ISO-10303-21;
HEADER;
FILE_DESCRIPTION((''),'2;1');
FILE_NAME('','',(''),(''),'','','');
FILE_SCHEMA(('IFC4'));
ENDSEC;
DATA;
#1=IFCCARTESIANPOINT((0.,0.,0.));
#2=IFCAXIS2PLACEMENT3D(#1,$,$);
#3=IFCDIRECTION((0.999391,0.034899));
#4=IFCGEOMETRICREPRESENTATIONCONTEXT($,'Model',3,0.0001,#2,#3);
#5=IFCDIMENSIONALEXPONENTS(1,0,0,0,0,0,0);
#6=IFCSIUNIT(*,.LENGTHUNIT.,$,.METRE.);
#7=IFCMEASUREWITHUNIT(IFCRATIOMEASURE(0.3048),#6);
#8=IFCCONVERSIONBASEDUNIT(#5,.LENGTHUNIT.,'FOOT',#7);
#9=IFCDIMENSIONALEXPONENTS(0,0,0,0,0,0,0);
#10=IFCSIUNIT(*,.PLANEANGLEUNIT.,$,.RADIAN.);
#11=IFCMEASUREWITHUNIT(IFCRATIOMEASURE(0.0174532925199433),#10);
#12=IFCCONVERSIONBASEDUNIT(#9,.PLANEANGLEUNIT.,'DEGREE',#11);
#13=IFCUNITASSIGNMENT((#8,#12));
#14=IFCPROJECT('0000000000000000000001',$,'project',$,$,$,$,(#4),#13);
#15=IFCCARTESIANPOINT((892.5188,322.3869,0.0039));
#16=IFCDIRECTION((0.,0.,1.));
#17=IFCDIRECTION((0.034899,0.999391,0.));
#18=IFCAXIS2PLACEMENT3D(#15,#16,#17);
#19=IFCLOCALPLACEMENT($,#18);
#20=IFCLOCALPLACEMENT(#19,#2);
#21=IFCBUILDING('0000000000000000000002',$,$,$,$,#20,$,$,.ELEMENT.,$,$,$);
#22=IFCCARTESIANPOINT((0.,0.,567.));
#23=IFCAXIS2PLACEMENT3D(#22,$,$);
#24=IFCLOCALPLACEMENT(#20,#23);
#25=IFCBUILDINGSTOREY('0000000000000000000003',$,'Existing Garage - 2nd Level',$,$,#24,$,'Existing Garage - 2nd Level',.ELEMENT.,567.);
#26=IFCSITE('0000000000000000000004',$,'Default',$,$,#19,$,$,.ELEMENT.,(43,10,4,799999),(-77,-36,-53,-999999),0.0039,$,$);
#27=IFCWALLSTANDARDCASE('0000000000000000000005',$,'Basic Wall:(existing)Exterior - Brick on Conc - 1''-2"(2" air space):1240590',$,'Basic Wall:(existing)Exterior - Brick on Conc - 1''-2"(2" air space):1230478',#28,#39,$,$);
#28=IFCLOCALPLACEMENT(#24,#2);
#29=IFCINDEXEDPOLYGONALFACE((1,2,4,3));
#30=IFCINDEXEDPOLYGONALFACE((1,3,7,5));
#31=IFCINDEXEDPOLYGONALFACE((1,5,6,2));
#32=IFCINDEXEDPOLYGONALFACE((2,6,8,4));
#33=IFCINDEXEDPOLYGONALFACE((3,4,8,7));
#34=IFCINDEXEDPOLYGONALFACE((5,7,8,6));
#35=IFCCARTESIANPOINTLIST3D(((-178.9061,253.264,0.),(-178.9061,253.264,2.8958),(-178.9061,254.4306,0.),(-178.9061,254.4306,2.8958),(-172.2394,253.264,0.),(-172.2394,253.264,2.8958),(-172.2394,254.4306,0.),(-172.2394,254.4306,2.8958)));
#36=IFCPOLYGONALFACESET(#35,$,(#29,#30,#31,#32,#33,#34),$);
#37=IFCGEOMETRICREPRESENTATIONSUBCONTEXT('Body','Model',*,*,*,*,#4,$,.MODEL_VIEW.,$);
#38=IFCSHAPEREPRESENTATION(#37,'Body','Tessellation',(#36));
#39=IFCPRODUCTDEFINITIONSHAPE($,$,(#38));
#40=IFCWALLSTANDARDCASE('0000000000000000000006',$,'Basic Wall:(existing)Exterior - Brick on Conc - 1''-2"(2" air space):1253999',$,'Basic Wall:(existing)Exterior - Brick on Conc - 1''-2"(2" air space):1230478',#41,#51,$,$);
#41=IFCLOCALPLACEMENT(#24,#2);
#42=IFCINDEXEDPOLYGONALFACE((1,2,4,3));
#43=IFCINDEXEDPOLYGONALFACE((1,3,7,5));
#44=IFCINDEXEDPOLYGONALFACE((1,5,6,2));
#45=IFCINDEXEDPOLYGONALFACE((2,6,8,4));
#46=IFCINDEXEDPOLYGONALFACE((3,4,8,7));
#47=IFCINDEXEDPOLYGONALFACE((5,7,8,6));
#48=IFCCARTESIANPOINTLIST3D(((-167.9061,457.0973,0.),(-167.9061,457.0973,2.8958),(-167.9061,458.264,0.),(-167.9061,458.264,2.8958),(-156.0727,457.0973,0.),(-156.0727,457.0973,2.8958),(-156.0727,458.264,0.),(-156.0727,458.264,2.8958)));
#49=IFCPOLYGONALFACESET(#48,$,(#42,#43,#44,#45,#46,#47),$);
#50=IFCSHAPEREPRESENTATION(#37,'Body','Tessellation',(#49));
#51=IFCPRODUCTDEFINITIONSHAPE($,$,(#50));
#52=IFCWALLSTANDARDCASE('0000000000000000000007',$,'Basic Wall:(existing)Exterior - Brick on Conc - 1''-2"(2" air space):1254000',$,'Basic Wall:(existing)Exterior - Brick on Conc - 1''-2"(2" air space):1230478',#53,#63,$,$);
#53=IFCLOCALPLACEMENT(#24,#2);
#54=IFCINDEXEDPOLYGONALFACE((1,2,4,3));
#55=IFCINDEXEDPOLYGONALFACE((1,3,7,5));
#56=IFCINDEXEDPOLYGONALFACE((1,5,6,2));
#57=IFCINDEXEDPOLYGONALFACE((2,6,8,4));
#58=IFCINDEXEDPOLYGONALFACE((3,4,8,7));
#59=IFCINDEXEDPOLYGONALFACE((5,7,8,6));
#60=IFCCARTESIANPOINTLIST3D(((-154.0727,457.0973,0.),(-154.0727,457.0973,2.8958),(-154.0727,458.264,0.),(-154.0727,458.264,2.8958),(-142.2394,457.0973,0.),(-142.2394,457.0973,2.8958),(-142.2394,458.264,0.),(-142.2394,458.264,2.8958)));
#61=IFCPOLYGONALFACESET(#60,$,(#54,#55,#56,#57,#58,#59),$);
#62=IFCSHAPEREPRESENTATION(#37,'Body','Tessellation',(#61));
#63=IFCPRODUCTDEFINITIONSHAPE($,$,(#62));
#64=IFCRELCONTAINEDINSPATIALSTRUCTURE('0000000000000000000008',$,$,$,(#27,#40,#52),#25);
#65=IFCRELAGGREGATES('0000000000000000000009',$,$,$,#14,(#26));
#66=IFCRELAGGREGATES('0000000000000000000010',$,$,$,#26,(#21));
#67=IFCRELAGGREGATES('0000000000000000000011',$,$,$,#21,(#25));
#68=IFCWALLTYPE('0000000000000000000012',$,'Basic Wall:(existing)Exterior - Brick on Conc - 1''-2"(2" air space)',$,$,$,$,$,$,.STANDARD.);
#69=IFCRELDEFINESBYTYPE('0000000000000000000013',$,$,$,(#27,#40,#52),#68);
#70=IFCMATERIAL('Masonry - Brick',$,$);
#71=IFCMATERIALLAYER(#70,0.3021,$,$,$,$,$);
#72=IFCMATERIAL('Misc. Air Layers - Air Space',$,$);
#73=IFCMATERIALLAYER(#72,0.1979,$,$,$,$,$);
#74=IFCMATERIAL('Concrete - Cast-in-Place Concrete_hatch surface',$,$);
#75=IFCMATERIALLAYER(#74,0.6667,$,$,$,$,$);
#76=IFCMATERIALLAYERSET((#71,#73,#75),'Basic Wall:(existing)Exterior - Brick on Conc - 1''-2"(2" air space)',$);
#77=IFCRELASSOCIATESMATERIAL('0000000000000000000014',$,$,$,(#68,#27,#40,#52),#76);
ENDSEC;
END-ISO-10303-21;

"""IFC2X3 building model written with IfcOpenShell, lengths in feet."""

from ifc_helpers import new_model, entity, si_unit, converted_unit, direction, frame, frame_2d, origin, place, context, subcontext, project, spatial, rectangle, extrude, material, layer, layer_set, layer_usage, type_object, element, save


model = new_model("IFC2X3")

# Units and contexts
model_context = context("Model", 3, precision=0.0001, world=origin(), true_north=direction((0.999391, 0.034899)))
body_context = subcontext(model_context, "Body", "Model", "MODEL_VIEW")
ifc_project = project(units=[converted_unit("LENGTHUNIT", "FOOT", entity("IfcRatioMeasure", 0.3048), si_unit("LENGTHUNIT", "METRE"), dimensions=[1, 0, 0, 0, 0, 0, 0]), converted_unit("PLANEANGLEUNIT", "DEGREE", entity("IfcRatioMeasure", 0.0174532925199433), si_unit("PLANEANGLEUNIT", "RADIAN"), dimensions=[0, 0, 0, 0, 0, 0, 0])], contexts=[model_context])

# Site, building, storey
site_placement = place(None, frame((892.5188, 322.3869, 0.0039), z_axis=(0.0, 0.0, 1.0), x_axis=(0.034899, 0.999391, 0.0)))
site = spatial("IfcSite", under=ifc_project, at=site_placement, Name="Default", CompositionType="ELEMENT", RefLatitude=(43, 10, 4, 799999), RefLongitude=(-77, -36, -53, -999999), RefElevation=0.0039)
building_placement = place(site_placement, origin())
building = spatial("IfcBuilding", under=site, at=building_placement, CompositionType="ELEMENT")
storey_placement = place(building_placement, frame((0.0, 0.0, 567.0)))
storey = spatial("IfcBuildingStorey", under=building, at=storey_placement, Name="Existing Garage - 2nd Level", LongName="Existing Garage - 2nd Level", CompositionType="ELEMENT", Elevation=567.0)

# Walls
ifc_material_1 = material(Name="Masonry - Brick")
ifc_layer_1 = layer(ifc_material_1, 0.3021)
ifc_material_2 = material(Name="Misc. Air Layers - Air Space")
ifc_layer_2 = layer(ifc_material_2, 0.1979)
ifc_material_3 = material(Name="Concrete - Cast-in-Place Concrete_hatch surface")
ifc_layer_3 = layer(ifc_material_3, 0.6667)
ifc_layer_set = layer_set([ifc_layer_1, ifc_layer_2, ifc_layer_3], Name="Basic Wall:(existing)Exterior - Brick on Conc - 1'-2\"(2\" air space)")
ifc_layer_usage_1 = layer_usage(ifc_layer_set, "AXIS2", "POSITIVE", -0.5833)
wall_type = type_object("IfcWallType", Name="Basic Wall:(existing)Exterior - Brick on Conc - 1'-2\"(2\" air space)", PredefinedType="STANDARD", material=ifc_layer_set)
wall_1_placement = place(storey_placement, frame((-178.9061, 253.8473, 0.0)))
element("IfcWallStandardCase", 1, at=wall_1_placement, inside=storey, type_object=wall_type, material=ifc_layer_usage_1, Name="Basic Wall:(existing)Exterior - Brick on Conc - 1'-2\"(2\" air space):1240590", ObjectType="Basic Wall:(existing)Exterior - Brick on Conc - 1'-2\"(2\" air space):1230478", context=body_context, shape_type="SweptSolid", body=[
    extrude(rectangle(XDim=6.6667, YDim=1.1667, at=frame_2d((3.3333, 0.0), x_axis=(-1.0, 0.0))), origin(), (0.0, 0.0, 1.0), 2.8958),
])
ifc_layer_usage_2 = layer_usage(ifc_layer_set, "AXIS2", "POSITIVE", -0.5833)
wall_2_placement = place(storey_placement, frame((-156.0727, 457.6806, 0.0), z_axis=(0.0, 0.0, 1.0), x_axis=(-1.0, 0.0, 0.0)))
element("IfcWallStandardCase", 2, at=wall_2_placement, inside=storey, type_object=wall_type, material=ifc_layer_usage_2, Name="Basic Wall:(existing)Exterior - Brick on Conc - 1'-2\"(2\" air space):1253999", ObjectType="Basic Wall:(existing)Exterior - Brick on Conc - 1'-2\"(2\" air space):1230478", context=body_context, shape_type="SweptSolid", body=[
    extrude(rectangle(XDim=11.8333, YDim=1.1667, at=frame_2d((5.9167, 0.0), x_axis=(-1.0, 0.0))), origin(), (0.0, 0.0, 1.0), 2.8958),
])
ifc_layer_usage_3 = layer_usage(ifc_layer_set, "AXIS2", "NEGATIVE", 0.5833)
wall_3_placement = place(storey_placement, frame((-154.0727, 457.6806, 0.0)))
element("IfcWallStandardCase", 3, at=wall_3_placement, inside=storey, type_object=wall_type, material=ifc_layer_usage_3, Name="Basic Wall:(existing)Exterior - Brick on Conc - 1'-2\"(2\" air space):1254000", ObjectType="Basic Wall:(existing)Exterior - Brick on Conc - 1'-2\"(2\" air space):1230478", context=body_context, shape_type="SweptSolid", body=[
    extrude(rectangle(XDim=11.8333, YDim=1.1667, at=frame_2d((5.9167, 0.0), x_axis=(-1.0, 0.0))), origin(), (0.0, 0.0, 1.0), 2.8958),
])

save(model, "model.ifc")
